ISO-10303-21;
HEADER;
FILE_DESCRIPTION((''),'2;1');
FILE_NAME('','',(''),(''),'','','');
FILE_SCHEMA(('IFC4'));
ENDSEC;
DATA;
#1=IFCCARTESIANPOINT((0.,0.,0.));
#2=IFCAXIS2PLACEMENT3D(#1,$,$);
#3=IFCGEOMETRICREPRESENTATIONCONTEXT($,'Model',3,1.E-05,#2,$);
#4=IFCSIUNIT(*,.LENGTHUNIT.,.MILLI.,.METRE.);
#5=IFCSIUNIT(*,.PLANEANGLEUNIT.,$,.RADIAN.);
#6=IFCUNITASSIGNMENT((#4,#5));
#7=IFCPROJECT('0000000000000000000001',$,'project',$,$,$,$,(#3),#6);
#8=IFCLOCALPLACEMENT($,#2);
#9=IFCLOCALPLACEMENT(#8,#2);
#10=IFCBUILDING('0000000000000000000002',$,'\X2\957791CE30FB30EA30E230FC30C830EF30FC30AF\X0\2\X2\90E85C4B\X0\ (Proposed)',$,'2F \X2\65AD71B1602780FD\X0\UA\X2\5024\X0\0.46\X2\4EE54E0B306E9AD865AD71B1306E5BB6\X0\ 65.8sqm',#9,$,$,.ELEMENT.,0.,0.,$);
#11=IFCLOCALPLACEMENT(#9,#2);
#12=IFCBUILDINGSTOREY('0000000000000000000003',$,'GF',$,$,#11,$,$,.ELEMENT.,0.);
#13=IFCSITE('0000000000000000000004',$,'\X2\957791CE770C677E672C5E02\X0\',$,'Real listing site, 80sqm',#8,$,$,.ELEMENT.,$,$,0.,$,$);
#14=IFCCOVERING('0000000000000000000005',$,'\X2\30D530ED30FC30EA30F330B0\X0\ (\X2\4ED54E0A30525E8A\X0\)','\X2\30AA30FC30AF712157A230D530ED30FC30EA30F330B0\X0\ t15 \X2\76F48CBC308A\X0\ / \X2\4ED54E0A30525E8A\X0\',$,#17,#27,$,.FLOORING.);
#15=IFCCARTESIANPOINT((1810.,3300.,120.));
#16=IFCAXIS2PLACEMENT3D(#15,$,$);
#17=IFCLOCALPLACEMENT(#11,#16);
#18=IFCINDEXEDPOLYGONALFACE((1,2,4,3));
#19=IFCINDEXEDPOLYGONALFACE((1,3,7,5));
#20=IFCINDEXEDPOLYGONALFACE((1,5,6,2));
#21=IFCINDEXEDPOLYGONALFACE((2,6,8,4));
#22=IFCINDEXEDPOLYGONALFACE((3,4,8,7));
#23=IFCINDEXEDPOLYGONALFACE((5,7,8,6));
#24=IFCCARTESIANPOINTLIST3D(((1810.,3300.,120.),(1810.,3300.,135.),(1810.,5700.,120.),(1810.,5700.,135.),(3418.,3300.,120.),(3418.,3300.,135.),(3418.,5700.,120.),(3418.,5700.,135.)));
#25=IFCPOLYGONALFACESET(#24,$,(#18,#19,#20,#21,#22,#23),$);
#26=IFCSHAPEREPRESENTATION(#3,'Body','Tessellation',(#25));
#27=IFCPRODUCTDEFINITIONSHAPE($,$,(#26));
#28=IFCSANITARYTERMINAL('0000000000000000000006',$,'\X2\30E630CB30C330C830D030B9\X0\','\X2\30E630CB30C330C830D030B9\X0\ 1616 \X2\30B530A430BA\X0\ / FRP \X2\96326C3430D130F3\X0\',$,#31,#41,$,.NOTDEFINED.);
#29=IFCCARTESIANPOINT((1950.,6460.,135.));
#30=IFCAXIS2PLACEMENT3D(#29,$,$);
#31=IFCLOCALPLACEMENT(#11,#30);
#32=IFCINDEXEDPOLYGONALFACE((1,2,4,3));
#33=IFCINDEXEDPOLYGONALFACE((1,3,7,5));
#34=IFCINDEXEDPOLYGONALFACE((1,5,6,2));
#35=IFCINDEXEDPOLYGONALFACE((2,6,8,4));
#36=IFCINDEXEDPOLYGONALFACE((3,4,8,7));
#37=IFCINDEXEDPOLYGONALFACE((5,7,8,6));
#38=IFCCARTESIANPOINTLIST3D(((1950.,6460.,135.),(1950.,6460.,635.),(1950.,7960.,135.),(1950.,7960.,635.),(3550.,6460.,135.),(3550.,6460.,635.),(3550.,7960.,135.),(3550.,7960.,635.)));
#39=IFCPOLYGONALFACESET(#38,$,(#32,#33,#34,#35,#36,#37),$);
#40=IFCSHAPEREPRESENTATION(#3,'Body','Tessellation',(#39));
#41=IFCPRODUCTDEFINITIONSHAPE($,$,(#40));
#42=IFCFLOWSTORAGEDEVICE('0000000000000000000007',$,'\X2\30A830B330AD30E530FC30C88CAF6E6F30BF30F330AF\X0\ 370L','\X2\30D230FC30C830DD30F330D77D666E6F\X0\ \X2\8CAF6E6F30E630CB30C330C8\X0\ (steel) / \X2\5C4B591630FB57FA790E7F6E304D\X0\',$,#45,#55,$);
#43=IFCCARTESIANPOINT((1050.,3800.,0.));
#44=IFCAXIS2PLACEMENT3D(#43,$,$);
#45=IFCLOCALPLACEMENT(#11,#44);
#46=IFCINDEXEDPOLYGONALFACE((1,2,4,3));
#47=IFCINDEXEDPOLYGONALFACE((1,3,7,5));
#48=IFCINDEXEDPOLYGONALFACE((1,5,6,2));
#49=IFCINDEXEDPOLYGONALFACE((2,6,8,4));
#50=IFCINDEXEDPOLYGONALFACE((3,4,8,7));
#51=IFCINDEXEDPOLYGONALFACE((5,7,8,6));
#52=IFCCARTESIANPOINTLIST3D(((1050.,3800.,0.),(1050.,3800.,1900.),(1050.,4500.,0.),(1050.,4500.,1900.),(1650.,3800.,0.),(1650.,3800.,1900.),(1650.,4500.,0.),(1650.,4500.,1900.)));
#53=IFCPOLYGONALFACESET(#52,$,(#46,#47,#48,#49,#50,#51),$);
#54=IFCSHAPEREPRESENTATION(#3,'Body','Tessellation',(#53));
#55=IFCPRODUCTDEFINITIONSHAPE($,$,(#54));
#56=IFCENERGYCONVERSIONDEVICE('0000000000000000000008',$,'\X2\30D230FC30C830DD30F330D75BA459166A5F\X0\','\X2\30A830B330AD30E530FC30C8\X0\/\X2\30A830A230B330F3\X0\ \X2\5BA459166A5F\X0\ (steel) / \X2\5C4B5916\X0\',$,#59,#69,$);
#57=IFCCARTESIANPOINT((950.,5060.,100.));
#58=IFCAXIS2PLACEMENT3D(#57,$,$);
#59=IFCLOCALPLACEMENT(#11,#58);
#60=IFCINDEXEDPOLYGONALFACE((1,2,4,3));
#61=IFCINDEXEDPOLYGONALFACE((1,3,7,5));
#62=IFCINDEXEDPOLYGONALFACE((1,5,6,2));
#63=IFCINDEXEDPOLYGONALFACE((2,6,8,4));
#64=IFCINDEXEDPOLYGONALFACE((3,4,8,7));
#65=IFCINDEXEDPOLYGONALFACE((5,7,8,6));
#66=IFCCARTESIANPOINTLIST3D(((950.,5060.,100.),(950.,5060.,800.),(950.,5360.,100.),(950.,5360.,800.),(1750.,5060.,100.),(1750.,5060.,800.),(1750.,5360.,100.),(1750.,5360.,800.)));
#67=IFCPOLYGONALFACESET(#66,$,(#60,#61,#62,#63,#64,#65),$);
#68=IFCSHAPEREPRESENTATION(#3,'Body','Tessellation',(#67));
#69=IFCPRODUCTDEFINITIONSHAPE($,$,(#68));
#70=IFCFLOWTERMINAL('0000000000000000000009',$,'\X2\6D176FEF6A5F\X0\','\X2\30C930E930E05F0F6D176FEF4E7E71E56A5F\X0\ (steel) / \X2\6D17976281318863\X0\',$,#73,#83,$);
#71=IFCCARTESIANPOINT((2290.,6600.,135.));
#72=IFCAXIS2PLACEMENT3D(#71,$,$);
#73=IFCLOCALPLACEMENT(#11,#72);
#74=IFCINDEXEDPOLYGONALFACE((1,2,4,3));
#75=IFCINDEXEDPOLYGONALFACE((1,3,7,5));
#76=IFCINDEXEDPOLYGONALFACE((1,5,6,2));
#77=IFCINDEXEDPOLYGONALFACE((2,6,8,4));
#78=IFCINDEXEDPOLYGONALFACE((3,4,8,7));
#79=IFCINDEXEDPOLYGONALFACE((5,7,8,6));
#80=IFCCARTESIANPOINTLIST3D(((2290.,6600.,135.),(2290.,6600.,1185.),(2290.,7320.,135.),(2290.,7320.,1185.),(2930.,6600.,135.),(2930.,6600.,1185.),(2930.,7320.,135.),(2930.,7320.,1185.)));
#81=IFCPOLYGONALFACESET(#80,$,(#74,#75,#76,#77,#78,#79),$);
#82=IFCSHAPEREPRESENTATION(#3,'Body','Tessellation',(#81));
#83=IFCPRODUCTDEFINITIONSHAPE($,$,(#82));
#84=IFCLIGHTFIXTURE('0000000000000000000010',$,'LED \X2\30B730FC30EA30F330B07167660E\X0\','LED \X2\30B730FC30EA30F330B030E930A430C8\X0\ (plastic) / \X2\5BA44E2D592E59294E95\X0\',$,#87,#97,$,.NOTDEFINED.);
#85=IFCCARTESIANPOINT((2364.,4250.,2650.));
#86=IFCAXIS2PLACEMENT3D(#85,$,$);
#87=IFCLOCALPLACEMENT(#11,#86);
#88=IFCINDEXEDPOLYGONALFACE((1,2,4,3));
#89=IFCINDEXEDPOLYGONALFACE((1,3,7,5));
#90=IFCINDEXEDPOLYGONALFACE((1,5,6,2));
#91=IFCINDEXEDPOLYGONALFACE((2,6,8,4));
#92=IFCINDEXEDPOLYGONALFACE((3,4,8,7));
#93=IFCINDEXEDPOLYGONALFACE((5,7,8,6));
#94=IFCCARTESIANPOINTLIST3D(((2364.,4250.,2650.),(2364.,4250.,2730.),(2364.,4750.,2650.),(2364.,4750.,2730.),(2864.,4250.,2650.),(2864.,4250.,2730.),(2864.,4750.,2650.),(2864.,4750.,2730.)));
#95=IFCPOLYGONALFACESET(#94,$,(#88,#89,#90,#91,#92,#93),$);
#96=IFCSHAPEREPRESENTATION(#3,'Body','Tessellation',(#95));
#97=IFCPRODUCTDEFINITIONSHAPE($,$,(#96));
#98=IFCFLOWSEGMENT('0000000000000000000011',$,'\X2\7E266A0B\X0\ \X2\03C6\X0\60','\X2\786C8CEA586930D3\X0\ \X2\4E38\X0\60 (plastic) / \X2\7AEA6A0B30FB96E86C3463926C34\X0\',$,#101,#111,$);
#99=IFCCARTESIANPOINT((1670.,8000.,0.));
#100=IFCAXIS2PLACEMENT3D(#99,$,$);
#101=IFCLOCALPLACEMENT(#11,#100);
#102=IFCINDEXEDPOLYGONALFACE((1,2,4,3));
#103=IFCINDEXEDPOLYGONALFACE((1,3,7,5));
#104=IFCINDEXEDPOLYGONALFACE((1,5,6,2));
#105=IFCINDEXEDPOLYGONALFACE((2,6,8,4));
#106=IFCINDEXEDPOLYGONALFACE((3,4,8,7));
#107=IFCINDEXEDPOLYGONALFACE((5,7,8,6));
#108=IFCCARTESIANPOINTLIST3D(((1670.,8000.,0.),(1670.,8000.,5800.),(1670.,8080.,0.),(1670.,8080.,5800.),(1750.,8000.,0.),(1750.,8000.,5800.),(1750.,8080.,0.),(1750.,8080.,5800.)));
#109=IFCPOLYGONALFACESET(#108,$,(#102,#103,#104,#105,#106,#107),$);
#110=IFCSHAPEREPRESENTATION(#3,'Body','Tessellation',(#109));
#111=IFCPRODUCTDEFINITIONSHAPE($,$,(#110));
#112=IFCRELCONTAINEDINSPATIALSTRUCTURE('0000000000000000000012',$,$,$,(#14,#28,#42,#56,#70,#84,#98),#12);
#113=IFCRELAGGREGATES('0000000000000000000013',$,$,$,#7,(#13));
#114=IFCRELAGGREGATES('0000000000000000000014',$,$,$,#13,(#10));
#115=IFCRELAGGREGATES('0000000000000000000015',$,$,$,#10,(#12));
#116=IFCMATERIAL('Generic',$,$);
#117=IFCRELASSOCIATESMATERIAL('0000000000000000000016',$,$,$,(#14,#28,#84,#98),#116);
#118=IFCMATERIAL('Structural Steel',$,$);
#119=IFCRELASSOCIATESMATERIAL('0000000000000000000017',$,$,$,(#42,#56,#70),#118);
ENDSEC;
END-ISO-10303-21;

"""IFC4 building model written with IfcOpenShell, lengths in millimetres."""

from ifc_helpers import new_model, si_unit, frame, frame_2d, origin, place, context, project, spatial, rectangle, extrude, material, element, save


model = new_model("IFC4")

# Units and contexts
model_context = context("Model", 3, precision=1e-05, world=origin())
ifc_project = project(units=[si_unit("LENGTHUNIT", "METRE", prefix="MILLI"), si_unit("PLANEANGLEUNIT", "RADIAN")], contexts=[model_context])

# Site, building, storey
site_placement = place(None, origin())
site = spatial("IfcSite", under=ifc_project, at=site_placement, Name="長野県松本市", ObjectType="Real listing site, 80sqm", CompositionType="ELEMENT", RefElevation=0.0)
building_placement = place(site_placement, origin())
building = spatial("IfcBuilding", under=site, at=building_placement, Name="長野・リモートワーク2部屋 (Proposed)", ObjectType="2F 断熱性能UA値0.46以下の高断熱の家 65.8sqm", CompositionType="ELEMENT", ElevationOfRefHeight=0.0, ElevationOfTerrain=0.0)
storey_placement = place(building_placement, origin())
storey = spatial("IfcBuildingStorey", under=building, at=storey_placement, Name="GF", CompositionType="ELEMENT", Elevation=0.0)

# Covering
ifc_material_1 = material(Name="Generic")
covering_1_placement = place(storey_placement, frame((1810.0, 3300.0, 120.0)))
element("IfcCovering", 1, at=covering_1_placement, inside=storey, material=ifc_material_1, Name="フローリング (仕上げ床)", Description="オーク無垢フローリング t15 直貼り / 仕上げ床", PredefinedType="FLOORING", context=model_context, shape_type="SweptSolid", body=[
    extrude(rectangle(XDim=1608.0, YDim=2400.0, at=frame_2d((804.0, 1200.0))), frame((1810.0, 3300.0, 120.0)), (0.0, 0.0, 1.0), 15.0),
])

# Sanitary terminal
sanitary_terminal_placement = place(storey_placement, frame((1950.0, 6460.0, 135.0)))
element("IfcSanitaryTerminal", 2, at=sanitary_terminal_placement, inside=storey, material=ifc_material_1, Name="ユニットバス", Description="ユニットバス 1616 サイズ / FRP 防水パン", PredefinedType="NOTDEFINED", context=model_context, shape_type="SweptSolid", body=[
    extrude(rectangle(XDim=1600.0, YDim=1500.0, at=frame_2d((800.0, 750.0))), frame((1950.0, 6460.0, 135.0)), (0.0, 0.0, 1.0), 500.0),
])

# Flow storage device
ifc_material_2 = material(Name="Structural Steel")
flow_storage_device_placement = place(storey_placement, frame((1050.0, 3800.0, 0.0)))
element("IfcFlowStorageDevice", 3, at=flow_storage_device_placement, inside=storey, material=ifc_material_2, Name="エコキュート貯湯タンク 370L", Description="ヒートポンプ給湯 貯湯ユニット (steel) / 屋外・基礎置き", context=model_context, shape_type="SweptSolid", body=[
    extrude(rectangle(XDim=600.0, YDim=700.0, at=frame_2d((300.0, 350.0))), frame((1050.0, 3800.0, 0.0)), (0.0, 0.0, 1.0), 1900.0),
])

# Energy conversion device
energy_conversion_device_placement = place(storey_placement, frame((950.0, 5060.0, 100.0)))
element("IfcEnergyConversionDevice", 4, at=energy_conversion_device_placement, inside=storey, material=ifc_material_2, Name="ヒートポンプ室外機", Description="エコキュート/エアコン 室外機 (steel) / 屋外", context=model_context, shape_type="SweptSolid", body=[
    extrude(rectangle(XDim=800.0, YDim=300.0, at=frame_2d((400.0, 150.0))), frame((950.0, 5060.0, 100.0)), (0.0, 0.0, 1.0), 700.0),
])

# Flow terminal
flow_terminal_placement = place(storey_placement, frame((2290.0, 6600.0, 135.0)))
element("IfcFlowTerminal", 5, at=flow_terminal_placement, inside=storey, material=ifc_material_2, Name="洗濯機", Description="ドラム式洗濯乾燥機 (steel) / 洗面脱衣", context=model_context, shape_type="SweptSolid", body=[
    extrude(rectangle(XDim=640.0, YDim=720.0, at=frame_2d((320.0, 360.0))), frame((2290.0, 6600.0, 135.0)), (0.0, 0.0, 1.0), 1050.0),
])

# Light fixture
light_fixture_placement = place(storey_placement, frame((2364.0, 4250.0, 2650.0)))
element("IfcLightFixture", 6, at=light_fixture_placement, inside=storey, material=ifc_material_1, Name="LED シーリング照明", Description="LED シーリングライト (plastic) / 室中央天井", PredefinedType="NOTDEFINED", context=model_context, shape_type="SweptSolid", body=[
    extrude(rectangle(XDim=500.0, YDim=500.0, at=frame_2d((250.0, 250.0))), frame((2364.0, 4250.0, 2650.0)), (0.0, 0.0, 1.0), 80.0),
])

# Flow segment
flow_segment_placement = place(storey_placement, frame((1670.0, 8000.0, 0.0)))
element("IfcFlowSegment", 7, at=flow_segment_placement, inside=storey, material=ifc_material_1, Name="縦樋 φ60", Description="硬質塩ビ 丸60 (plastic) / 竪樋・雨水排水", context=model_context, shape_type="SweptSolid", body=[
    extrude(rectangle(XDim=80.0, YDim=80.0, at=frame_2d((40.0, 40.0))), frame((1670.0, 8000.0, 0.0)), (0.0, 0.0, 1.0), 5800.0),
])

save(model, "model.ifc")
